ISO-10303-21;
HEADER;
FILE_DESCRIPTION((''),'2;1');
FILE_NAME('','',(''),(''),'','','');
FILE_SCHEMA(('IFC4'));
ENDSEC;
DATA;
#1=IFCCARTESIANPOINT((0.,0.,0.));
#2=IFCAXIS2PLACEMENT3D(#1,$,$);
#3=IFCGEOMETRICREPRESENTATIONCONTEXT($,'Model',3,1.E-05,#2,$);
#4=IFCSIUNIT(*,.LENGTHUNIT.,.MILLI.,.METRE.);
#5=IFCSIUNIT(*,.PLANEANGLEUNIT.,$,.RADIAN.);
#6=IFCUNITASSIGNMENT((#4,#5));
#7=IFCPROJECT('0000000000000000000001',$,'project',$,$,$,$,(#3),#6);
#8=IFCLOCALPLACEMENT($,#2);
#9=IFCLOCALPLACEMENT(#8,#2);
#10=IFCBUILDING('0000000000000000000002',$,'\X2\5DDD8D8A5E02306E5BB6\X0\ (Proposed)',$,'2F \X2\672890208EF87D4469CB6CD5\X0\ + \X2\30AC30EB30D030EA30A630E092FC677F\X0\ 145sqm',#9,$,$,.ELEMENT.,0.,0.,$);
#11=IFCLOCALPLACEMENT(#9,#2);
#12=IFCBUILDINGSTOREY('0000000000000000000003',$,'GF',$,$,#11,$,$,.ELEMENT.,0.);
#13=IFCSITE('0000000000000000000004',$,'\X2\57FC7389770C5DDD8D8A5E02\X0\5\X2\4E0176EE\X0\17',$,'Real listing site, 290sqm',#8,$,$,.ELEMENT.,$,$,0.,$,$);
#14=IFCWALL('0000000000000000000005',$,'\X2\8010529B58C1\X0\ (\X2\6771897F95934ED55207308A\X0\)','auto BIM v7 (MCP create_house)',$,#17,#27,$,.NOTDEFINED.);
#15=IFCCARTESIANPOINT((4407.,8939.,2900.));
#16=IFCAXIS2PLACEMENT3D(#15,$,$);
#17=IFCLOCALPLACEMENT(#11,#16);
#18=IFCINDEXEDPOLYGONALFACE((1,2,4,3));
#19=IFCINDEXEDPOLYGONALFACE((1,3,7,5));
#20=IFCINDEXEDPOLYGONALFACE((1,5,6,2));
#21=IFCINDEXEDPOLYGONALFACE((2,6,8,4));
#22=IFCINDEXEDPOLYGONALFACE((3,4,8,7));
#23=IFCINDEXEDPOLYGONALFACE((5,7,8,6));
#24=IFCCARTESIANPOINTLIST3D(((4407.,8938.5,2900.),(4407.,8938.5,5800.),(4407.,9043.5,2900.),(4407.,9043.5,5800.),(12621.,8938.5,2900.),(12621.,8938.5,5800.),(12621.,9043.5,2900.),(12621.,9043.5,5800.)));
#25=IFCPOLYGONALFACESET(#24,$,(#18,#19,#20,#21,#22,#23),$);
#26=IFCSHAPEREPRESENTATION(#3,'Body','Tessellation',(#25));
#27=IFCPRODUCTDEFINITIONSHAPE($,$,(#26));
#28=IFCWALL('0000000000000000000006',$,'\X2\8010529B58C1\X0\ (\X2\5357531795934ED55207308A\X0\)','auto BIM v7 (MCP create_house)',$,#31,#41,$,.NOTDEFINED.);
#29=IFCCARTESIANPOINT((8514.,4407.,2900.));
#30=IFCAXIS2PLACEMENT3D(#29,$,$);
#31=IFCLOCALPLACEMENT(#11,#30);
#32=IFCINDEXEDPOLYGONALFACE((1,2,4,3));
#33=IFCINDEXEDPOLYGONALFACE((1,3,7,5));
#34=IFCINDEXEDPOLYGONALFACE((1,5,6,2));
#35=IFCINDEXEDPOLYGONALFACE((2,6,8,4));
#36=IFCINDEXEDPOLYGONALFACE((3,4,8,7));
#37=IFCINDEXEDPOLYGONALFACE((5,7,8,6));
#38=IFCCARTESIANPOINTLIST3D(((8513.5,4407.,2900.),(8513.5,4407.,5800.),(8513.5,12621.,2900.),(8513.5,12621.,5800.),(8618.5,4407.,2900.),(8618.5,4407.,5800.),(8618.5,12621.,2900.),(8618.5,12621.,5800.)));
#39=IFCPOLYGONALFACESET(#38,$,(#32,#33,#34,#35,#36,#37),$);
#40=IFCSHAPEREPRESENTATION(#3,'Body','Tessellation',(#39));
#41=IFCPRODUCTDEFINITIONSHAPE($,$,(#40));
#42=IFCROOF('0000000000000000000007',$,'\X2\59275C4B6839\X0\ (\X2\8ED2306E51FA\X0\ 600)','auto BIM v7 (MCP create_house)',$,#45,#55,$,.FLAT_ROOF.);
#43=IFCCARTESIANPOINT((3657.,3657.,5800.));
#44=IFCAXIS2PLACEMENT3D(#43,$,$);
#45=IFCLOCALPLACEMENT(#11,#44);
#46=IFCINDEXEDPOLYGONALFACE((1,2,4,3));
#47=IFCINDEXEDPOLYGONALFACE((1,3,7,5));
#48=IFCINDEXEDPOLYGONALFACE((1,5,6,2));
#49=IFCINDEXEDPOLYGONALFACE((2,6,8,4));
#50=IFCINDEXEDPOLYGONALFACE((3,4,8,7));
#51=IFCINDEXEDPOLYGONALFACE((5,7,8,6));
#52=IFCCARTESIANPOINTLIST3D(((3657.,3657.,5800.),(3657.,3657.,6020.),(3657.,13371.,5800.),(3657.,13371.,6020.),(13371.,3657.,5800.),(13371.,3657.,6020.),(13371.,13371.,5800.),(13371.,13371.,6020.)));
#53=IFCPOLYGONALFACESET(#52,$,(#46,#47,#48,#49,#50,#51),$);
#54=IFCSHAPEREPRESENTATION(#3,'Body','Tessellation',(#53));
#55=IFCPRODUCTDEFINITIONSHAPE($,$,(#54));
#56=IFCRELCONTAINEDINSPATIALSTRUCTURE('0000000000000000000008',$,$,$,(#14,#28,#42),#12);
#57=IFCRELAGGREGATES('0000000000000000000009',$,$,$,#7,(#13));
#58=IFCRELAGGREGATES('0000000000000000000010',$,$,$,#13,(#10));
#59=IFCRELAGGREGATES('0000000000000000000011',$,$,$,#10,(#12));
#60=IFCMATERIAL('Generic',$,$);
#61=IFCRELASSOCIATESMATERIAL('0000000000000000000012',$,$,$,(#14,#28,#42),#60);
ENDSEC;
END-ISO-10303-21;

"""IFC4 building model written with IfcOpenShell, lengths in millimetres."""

from ifc_helpers import new_model, si_unit, frame, frame_2d, origin, place, context, project, spatial, rectangle, extrude, material, element, save


model = new_model("IFC4")

# Units and contexts
model_context = context("Model", 3, precision=1e-05, world=origin())
ifc_project = project(units=[si_unit("LENGTHUNIT", "METRE", prefix="MILLI"), si_unit("PLANEANGLEUNIT", "RADIAN")], contexts=[model_context])

# Site, building, storey
site_placement = place(None, origin())
site = spatial("IfcSite", under=ifc_project, at=site_placement, Name="埼玉県川越市5丁目17", ObjectType="Real listing site, 290sqm", CompositionType="ELEMENT", RefElevation=0.0)
building_placement = place(site_placement, origin())
building = spatial("IfcBuilding", under=site, at=building_placement, Name="川越市の家 (Proposed)", ObjectType="2F 木造軸組構法 + ガルバリウム鋼板 145sqm", CompositionType="ELEMENT", ElevationOfRefHeight=0.0, ElevationOfTerrain=0.0)
storey_placement = place(building_placement, origin())
storey = spatial("IfcBuildingStorey", under=building, at=storey_placement, Name="GF", CompositionType="ELEMENT", Elevation=0.0)

# Shared definitions
ifc_material = material(Name="Generic")

# Walls
wall_1_placement = place(storey_placement, frame((4407.0, 8939.0, 2900.0)))
element("IfcWall", 1, at=wall_1_placement, inside=storey, material=ifc_material, Name="耐力壁 (東西間仕切り)", Description="auto BIM v7 (MCP create_house)", PredefinedType="NOTDEFINED", context=model_context, shape_type="SweptSolid", body=[
    extrude(rectangle(XDim=8214.0, YDim=105.0, at=frame_2d((4107.0, 52.0))), frame((4407.0, 8939.0, 2900.0)), (0.0, 0.0, 1.0), 2900.0),
])
wall_2_placement = place(storey_placement, frame((8514.0, 4407.0, 2900.0)))
element("IfcWall", 2, at=wall_2_placement, inside=storey, material=ifc_material, Name="耐力壁 (南北間仕切り)", Description="auto BIM v7 (MCP create_house)", PredefinedType="NOTDEFINED", context=model_context, shape_type="SweptSolid", body=[
    extrude(rectangle(XDim=105.0, YDim=8214.0, at=frame_2d((52.0, 4107.0))), frame((8514.0, 4407.0, 2900.0)), (0.0, 0.0, 1.0), 2900.0),
])

# Roof
roof_placement = place(storey_placement, frame((3657.0, 3657.0, 5800.0)))
element("IfcRoof", 3, at=roof_placement, inside=storey, material=ifc_material, Name="大屋根 (軒の出 600)", Description="auto BIM v7 (MCP create_house)", PredefinedType="FLAT_ROOF", context=model_context, shape_type="SweptSolid", body=[
    extrude(rectangle(XDim=9714.0, YDim=9714.0, at=frame_2d((4857.0, 4857.0))), frame((3657.0, 3657.0, 5800.0)), (0.0, 0.0, 1.0), 220.0),
])

save(model, "model.ifc")
